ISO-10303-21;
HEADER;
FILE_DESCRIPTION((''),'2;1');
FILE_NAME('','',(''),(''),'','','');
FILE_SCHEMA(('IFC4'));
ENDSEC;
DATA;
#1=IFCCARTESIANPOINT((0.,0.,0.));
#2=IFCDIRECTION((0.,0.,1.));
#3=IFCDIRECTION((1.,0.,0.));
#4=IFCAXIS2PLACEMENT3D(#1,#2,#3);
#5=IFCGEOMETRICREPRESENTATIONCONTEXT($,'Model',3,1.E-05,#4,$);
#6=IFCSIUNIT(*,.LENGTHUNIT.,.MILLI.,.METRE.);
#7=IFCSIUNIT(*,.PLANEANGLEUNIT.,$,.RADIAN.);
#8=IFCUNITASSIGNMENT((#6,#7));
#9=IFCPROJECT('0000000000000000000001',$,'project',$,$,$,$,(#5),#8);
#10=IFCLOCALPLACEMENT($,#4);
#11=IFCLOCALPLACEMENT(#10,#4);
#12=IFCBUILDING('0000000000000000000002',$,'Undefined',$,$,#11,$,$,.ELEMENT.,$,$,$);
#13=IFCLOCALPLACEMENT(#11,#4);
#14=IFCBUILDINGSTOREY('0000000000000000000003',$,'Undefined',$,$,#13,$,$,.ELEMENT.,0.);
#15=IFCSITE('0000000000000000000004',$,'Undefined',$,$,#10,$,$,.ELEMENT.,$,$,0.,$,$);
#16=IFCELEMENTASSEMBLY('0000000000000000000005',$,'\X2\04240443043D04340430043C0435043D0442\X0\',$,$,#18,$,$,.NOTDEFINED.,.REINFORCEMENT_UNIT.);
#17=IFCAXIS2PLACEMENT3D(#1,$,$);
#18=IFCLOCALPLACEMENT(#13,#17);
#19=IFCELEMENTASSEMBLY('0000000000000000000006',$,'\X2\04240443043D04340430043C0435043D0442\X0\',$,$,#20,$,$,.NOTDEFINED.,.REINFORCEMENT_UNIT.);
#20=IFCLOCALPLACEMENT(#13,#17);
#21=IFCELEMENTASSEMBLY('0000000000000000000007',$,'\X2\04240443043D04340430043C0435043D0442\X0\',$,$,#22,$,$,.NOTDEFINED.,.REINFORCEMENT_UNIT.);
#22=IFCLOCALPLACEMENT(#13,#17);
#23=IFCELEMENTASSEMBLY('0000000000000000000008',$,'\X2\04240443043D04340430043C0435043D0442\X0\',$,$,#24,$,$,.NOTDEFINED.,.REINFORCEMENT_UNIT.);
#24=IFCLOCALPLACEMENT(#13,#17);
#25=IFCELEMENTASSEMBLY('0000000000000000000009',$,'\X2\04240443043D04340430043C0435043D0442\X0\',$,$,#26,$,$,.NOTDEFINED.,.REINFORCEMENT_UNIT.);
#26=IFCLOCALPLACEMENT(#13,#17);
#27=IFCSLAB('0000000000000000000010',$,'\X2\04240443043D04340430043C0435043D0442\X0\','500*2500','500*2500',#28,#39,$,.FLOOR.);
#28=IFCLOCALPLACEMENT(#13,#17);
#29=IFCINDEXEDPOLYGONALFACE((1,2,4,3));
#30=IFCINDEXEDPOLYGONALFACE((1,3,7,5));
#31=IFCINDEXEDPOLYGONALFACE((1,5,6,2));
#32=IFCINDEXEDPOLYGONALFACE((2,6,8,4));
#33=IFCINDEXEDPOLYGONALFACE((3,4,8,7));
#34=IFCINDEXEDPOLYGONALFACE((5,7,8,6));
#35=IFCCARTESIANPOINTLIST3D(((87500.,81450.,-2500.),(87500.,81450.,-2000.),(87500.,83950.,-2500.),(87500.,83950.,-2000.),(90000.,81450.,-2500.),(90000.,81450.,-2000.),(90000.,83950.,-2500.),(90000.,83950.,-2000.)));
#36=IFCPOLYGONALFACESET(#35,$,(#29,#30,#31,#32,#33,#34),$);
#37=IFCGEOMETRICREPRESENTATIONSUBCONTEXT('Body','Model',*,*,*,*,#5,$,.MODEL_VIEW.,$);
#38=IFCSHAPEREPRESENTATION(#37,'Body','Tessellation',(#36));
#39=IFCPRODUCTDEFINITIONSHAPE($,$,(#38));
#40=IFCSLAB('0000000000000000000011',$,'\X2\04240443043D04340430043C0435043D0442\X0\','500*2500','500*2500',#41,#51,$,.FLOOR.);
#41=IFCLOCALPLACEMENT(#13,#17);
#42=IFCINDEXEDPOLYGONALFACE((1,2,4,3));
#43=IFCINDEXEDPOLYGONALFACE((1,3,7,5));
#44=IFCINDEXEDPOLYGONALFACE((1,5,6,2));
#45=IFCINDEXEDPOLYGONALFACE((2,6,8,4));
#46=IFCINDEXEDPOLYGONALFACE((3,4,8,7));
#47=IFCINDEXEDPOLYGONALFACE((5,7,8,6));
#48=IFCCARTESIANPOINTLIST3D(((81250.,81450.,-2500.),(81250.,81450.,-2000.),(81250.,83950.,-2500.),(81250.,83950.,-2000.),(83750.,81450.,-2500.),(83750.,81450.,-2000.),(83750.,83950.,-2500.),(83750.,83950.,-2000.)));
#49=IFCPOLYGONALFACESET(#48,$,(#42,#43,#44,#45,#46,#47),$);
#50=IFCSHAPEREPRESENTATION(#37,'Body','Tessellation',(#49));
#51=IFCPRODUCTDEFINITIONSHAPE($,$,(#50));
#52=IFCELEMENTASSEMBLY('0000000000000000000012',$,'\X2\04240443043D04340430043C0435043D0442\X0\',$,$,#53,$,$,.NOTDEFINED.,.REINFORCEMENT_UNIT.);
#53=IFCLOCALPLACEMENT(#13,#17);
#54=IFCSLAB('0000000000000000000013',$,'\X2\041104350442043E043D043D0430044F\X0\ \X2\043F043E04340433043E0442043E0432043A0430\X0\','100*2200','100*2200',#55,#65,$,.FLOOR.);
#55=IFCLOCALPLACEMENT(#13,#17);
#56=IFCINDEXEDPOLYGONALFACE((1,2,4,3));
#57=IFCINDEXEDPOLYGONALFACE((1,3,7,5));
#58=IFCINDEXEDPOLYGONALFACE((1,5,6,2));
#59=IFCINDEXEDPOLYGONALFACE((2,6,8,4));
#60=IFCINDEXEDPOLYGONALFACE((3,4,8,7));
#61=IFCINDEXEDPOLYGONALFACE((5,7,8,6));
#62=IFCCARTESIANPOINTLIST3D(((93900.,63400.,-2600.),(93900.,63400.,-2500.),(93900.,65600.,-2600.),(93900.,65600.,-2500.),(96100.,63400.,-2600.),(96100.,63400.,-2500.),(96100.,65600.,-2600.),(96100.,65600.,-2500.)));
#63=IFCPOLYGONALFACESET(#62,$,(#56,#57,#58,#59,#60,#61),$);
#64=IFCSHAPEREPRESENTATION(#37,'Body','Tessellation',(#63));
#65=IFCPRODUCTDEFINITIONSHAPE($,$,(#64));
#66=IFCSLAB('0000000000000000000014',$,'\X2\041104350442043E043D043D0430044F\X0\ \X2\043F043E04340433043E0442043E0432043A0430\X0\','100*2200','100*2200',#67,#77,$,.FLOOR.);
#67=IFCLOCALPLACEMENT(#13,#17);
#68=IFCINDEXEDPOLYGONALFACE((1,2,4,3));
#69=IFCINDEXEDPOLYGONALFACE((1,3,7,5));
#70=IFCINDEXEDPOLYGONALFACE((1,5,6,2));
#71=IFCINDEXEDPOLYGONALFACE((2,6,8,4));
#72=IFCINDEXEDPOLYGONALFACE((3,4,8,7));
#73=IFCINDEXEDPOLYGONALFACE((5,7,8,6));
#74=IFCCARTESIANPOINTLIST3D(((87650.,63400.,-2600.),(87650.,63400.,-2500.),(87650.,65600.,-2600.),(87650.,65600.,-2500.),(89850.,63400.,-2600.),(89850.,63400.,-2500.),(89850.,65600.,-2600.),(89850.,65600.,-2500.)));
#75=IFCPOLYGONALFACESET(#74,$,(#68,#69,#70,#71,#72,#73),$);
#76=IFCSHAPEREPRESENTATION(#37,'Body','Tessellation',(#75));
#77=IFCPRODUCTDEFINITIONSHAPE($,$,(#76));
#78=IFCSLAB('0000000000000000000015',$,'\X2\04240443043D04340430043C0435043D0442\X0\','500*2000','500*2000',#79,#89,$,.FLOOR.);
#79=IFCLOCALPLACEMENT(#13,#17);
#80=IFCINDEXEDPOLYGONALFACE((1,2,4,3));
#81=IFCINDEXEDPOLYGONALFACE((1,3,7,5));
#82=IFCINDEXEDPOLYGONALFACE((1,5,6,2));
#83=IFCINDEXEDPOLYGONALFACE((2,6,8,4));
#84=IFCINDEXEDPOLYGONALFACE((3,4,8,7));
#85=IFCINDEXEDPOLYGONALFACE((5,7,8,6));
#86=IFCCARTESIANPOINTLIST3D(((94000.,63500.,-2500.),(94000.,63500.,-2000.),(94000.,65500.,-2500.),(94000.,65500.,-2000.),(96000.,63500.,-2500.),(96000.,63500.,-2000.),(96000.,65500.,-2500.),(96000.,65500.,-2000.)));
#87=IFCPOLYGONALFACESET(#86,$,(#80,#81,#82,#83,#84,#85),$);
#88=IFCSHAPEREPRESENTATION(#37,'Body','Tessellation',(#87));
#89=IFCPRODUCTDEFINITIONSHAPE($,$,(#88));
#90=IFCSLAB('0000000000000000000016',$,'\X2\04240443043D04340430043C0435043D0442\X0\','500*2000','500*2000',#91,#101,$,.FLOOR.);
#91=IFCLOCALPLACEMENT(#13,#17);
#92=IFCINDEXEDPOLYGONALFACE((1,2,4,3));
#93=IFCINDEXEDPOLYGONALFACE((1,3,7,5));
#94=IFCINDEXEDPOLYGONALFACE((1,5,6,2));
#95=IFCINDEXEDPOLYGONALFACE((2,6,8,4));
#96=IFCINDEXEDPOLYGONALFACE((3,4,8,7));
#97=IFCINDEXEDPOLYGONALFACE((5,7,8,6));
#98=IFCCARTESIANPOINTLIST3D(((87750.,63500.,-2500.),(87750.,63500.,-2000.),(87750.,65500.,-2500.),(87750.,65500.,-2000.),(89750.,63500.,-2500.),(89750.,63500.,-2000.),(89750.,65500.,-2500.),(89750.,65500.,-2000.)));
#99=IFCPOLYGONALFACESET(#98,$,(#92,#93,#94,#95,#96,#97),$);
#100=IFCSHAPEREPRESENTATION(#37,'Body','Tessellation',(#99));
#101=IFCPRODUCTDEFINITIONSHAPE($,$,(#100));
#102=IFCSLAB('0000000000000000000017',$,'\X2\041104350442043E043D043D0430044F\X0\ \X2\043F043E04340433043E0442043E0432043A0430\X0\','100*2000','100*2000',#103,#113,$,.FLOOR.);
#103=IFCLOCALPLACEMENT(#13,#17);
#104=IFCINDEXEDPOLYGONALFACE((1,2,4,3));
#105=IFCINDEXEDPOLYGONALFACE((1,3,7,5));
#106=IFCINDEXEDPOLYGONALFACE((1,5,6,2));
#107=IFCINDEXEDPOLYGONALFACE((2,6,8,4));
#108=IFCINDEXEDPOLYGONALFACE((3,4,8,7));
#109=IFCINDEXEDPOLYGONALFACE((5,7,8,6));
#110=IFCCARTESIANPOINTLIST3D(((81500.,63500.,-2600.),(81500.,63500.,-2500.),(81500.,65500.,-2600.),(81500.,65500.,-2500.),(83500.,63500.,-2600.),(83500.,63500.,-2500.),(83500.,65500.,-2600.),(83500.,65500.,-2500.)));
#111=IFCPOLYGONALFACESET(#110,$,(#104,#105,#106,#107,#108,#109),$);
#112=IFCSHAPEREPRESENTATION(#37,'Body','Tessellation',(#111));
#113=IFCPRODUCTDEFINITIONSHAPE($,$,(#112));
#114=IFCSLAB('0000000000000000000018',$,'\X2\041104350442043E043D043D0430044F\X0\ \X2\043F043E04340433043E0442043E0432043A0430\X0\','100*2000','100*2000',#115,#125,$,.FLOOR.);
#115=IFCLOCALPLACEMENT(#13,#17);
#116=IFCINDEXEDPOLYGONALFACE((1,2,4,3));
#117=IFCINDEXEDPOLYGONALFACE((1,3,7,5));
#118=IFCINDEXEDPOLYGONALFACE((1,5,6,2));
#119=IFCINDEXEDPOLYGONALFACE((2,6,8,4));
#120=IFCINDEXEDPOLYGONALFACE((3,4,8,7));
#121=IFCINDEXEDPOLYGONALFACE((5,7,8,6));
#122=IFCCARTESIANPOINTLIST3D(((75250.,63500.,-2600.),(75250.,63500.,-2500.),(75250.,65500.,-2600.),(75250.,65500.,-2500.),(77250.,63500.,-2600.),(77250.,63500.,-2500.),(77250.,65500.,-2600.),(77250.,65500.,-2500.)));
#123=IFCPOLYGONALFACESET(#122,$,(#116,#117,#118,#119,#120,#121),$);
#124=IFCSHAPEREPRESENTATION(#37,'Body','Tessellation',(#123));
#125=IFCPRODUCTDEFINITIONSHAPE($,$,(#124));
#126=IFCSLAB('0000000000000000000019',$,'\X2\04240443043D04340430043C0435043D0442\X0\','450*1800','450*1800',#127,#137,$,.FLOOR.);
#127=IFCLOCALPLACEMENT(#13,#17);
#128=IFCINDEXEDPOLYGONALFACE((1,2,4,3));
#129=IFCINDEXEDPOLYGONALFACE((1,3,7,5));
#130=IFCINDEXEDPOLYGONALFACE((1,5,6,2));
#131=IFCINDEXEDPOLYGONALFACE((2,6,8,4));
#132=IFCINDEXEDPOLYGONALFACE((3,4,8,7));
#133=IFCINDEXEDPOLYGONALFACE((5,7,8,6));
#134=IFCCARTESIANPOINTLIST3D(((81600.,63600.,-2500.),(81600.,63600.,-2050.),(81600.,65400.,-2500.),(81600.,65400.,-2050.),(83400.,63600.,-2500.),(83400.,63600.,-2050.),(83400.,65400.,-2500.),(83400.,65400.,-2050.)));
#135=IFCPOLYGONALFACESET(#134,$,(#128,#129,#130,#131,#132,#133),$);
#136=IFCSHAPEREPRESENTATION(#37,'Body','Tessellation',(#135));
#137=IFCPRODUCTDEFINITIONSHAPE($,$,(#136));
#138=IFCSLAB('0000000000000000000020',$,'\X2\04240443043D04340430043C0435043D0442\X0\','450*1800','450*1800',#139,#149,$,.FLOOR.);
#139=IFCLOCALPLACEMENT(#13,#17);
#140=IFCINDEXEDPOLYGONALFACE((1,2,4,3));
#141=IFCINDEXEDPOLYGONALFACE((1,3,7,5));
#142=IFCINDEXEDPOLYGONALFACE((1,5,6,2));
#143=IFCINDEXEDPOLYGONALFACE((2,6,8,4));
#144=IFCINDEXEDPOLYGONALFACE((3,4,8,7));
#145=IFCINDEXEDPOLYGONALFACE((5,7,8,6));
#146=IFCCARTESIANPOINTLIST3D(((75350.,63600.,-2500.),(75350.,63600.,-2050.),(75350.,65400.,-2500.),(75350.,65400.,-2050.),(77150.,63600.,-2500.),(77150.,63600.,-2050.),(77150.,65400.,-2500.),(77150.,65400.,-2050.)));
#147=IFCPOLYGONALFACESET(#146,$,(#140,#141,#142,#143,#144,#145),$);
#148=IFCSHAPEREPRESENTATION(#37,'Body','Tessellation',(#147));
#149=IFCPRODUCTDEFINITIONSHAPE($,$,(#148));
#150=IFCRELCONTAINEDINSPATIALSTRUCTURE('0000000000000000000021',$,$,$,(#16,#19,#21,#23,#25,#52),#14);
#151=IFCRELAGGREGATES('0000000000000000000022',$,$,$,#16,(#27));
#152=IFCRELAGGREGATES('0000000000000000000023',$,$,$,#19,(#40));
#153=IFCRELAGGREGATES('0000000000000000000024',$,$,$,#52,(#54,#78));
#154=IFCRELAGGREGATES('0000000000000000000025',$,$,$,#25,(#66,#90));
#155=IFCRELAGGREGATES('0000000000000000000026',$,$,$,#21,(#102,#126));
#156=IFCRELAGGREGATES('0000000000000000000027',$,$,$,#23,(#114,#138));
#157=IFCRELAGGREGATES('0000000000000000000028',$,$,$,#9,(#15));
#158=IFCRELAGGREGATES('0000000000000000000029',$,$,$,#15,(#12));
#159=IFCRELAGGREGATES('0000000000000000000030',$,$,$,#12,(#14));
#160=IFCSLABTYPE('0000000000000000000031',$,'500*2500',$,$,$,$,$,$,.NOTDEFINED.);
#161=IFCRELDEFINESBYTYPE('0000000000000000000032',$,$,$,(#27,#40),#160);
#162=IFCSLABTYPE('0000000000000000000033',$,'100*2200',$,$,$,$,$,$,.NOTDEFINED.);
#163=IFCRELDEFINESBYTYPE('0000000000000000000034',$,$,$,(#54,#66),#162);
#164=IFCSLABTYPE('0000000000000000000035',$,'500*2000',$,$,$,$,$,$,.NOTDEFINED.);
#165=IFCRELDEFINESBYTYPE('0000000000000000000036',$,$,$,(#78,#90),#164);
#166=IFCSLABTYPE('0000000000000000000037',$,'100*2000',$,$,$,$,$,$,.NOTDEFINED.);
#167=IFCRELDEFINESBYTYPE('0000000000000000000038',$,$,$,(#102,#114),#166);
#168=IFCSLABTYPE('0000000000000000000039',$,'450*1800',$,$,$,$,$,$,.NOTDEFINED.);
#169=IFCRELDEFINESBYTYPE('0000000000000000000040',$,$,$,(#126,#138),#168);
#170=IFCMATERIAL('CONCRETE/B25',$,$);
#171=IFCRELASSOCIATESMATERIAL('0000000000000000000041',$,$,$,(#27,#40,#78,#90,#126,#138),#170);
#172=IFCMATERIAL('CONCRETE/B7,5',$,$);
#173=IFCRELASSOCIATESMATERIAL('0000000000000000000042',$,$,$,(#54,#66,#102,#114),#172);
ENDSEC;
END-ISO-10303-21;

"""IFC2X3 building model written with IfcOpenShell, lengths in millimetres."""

from ifc_helpers import new_model, si_unit, frame, origin_with_axes, place, context, subcontext, project, spatial, polyline, outline, extrude, material, type_object, element, aggregate, save


model = new_model("IFC2X3")

# Units and contexts
model_context = context("Model", 3, precision=1e-05, world=origin_with_axes())
body_context = subcontext(model_context, "Body", "Model", "MODEL_VIEW")
ifc_project = project(units=[si_unit("LENGTHUNIT", "METRE", prefix="MILLI"), si_unit("PLANEANGLEUNIT", "RADIAN")], contexts=[model_context])

# Site, building, storey
site_placement = place(None, origin_with_axes())
site = spatial("IfcSite", under=ifc_project, at=site_placement, Name="Undefined", CompositionType="ELEMENT", RefElevation=0.0)
building_placement = place(site_placement, origin_with_axes())
building = spatial("IfcBuilding", under=site, at=building_placement, Name="Undefined", CompositionType="ELEMENT")
storey_placement = place(building_placement, origin_with_axes())
storey = spatial("IfcBuildingStorey", under=building, at=storey_placement, Name="Undefined", CompositionType="ELEMENT", Elevation=0.0)

# Element assemblies
ifc_material_1 = material(Name="CONCRETE/B25")
assembly_1_placement = place(storey_placement, origin_with_axes())
assembly_1 = element("IfcElementAssembly", 1, at=assembly_1_placement, inside=storey, Name="Фундамент", AssemblyPlace="NOTDEFINED", PredefinedType="REINFORCEMENT_UNIT")
assembly_2_placement = place(storey_placement, origin_with_axes())
assembly_2 = element("IfcElementAssembly", 2, at=assembly_2_placement, inside=storey, Name="Фундамент", AssemblyPlace="NOTDEFINED", PredefinedType="REINFORCEMENT_UNIT")

# Element assemblies
assembly_3_placement = place(storey_placement, origin_with_axes())
assembly_3 = element("IfcElementAssembly", 3, at=assembly_3_placement, inside=storey, Name="Фундамент", AssemblyPlace="NOTDEFINED", PredefinedType="REINFORCEMENT_UNIT")
assembly_4_placement = place(storey_placement, origin_with_axes())
assembly_4 = element("IfcElementAssembly", 4, at=assembly_4_placement, inside=storey, Name="Фундамент", AssemblyPlace="NOTDEFINED", PredefinedType="REINFORCEMENT_UNIT")
assembly_5_placement = place(storey_placement, origin_with_axes())
assembly_5 = element("IfcElementAssembly", 5, at=assembly_5_placement, inside=storey, Name="Фундамент", AssemblyPlace="NOTDEFINED", PredefinedType="REINFORCEMENT_UNIT")

# Slabs
ifc_material_2 = material(Name="CONCRETE/B7,5")
slab_type_1 = type_object("IfcSlabType", Name="500*2500", PredefinedType="NOTDEFINED")
slab_1_placement = place(assembly_1_placement, frame((87500.0, 83950.0, -2250.0), z_axis=(0.0, 0.0, 1.0), x_axis=(0.0, -1.0, 0.0)))
slab_1 = element("IfcSlab", 6, at=slab_1_placement, type_object=slab_type_1, material=ifc_material_1, Name="Фундамент", Description="500*2500", ObjectType="500*2500", PredefinedType="FLOOR", context=body_context, shape_type="SweptSolid", body=[
    extrude(outline(polyline([(0.0, 0.0), (2500.0, 0.0), (2500.0, 2500.0), (0.0, 2500.0), (0.0, 0.0)])), frame((0.0, 0.0, -250.0), z_axis=(0.0, 0.0, 1.0), x_axis=(1.0, 0.0, 0.0)), (0.0, 0.0, 1.0), 500.0),
])
aggregate(assembly_1, [slab_1])
slab_2_placement = place(assembly_2_placement, frame((81250.0, 83950.0, -2250.0), z_axis=(0.0, 0.0, 1.0), x_axis=(0.0, -1.0, 0.0)))
slab_2 = element("IfcSlab", 7, at=slab_2_placement, type_object=slab_type_1, material=ifc_material_1, Name="Фундамент", Description="500*2500", ObjectType="500*2500", PredefinedType="FLOOR", context=body_context, shape_type="SweptSolid", body=[
    extrude(outline(polyline([(0.0, 0.0), (2500.0, 0.0), (2500.0, 2500.0), (0.0, 2500.0), (0.0, 0.0)])), frame((0.0, 0.0, -250.0), z_axis=(0.0, 0.0, 1.0), x_axis=(1.0, 0.0, 0.0)), (0.0, 0.0, 1.0), 500.0),
])
aggregate(assembly_2, [slab_2])

# Element assembly, slab
assembly_6_placement = place(storey_placement, origin_with_axes())
assembly_6 = element("IfcElementAssembly", 8, at=assembly_6_placement, inside=storey, Name="Фундамент", AssemblyPlace="NOTDEFINED", PredefinedType="REINFORCEMENT_UNIT")
slab_type_2 = type_object("IfcSlabType", Name="100*2200", PredefinedType="NOTDEFINED")
slab_3_placement = place(assembly_6_placement, frame((93900.0, 65600.0, -2550.0), z_axis=(0.0, 0.0, 1.0), x_axis=(0.0, -1.0, 0.0)))
slab_3 = element("IfcSlab", 9, at=slab_3_placement, type_object=slab_type_2, material=ifc_material_2, Name="Бетонная подготовка", Description="100*2200", ObjectType="100*2200", PredefinedType="FLOOR", context=body_context, shape_type="SweptSolid", body=[
    extrude(outline(polyline([(0.0, 0.0), (2200.0, 0.0), (2200.0, 2200.0), (0.0, 2200.0), (0.0, 0.0)])), frame((0.0, 0.0, -50.0), z_axis=(0.0, 0.0, 1.0), x_axis=(1.0, 0.0, 0.0)), (0.0, 0.0, 1.0), 100.0),
])

# Slabs
slab_4_placement = place(assembly_5_placement, frame((87650.0, 65600.0, -2550.0), z_axis=(0.0, 0.0, 1.0), x_axis=(0.0, -1.0, 0.0)))
slab_4 = element("IfcSlab", 10, at=slab_4_placement, type_object=slab_type_2, material=ifc_material_2, Name="Бетонная подготовка", Description="100*2200", ObjectType="100*2200", PredefinedType="FLOOR", context=body_context, shape_type="SweptSolid", body=[
    extrude(outline(polyline([(0.0, 0.0), (2200.0, 0.0), (2200.0, 2200.0), (0.0, 2200.0), (0.0, 0.0)])), frame((0.0, 0.0, -50.0), z_axis=(0.0, 0.0, 1.0), x_axis=(1.0, 0.0, 0.0)), (0.0, 0.0, 1.0), 100.0),
])
slab_type_3 = type_object("IfcSlabType", Name="500*2000", PredefinedType="NOTDEFINED")
slab_5_placement = place(assembly_6_placement, frame((94000.0, 65500.0, -2250.0), z_axis=(0.0, 0.0, 1.0), x_axis=(0.0, -1.0, 0.0)))
slab_5 = element("IfcSlab", 11, at=slab_5_placement, type_object=slab_type_3, material=ifc_material_1, Name="Фундамент", Description="500*2000", ObjectType="500*2000", PredefinedType="FLOOR", context=body_context, shape_type="SweptSolid", body=[
    extrude(outline(polyline([(0.0, 0.0), (2000.0, 0.0), (2000.0, 2000.0), (0.0, 2000.0), (0.0, 0.0)])), frame((0.0, 0.0, -250.0), z_axis=(0.0, 0.0, 1.0), x_axis=(1.0, 0.0, 0.0)), (0.0, 0.0, 1.0), 500.0),
])
aggregate(assembly_6, [slab_3, slab_5])
slab_6_placement = place(assembly_5_placement, frame((87750.0, 65500.0, -2250.0), z_axis=(0.0, 0.0, 1.0), x_axis=(0.0, -1.0, 0.0)))
slab_6 = element("IfcSlab", 12, at=slab_6_placement, type_object=slab_type_3, material=ifc_material_1, Name="Фундамент", Description="500*2000", ObjectType="500*2000", PredefinedType="FLOOR", context=body_context, shape_type="SweptSolid", body=[
    extrude(outline(polyline([(0.0, 0.0), (2000.0, 0.0), (2000.0, 2000.0), (0.0, 2000.0), (0.0, 0.0)])), frame((0.0, 0.0, -250.0), z_axis=(0.0, 0.0, 1.0), x_axis=(1.0, 0.0, 0.0)), (0.0, 0.0, 1.0), 500.0),
])
aggregate(assembly_5, [slab_4, slab_6])
slab_type_4 = type_object("IfcSlabType", Name="100*2000", PredefinedType="NOTDEFINED")
slab_7_placement = place(assembly_3_placement, frame((81500.0, 65500.0, -2550.0), z_axis=(0.0, 0.0, 1.0), x_axis=(0.0, -1.0, 0.0)))
slab_7 = element("IfcSlab", 13, at=slab_7_placement, type_object=slab_type_4, material=ifc_material_2, Name="Бетонная подготовка", Description="100*2000", ObjectType="100*2000", PredefinedType="FLOOR", context=body_context, shape_type="SweptSolid", body=[
    extrude(outline(polyline([(0.0, 0.0), (2000.0, 0.0), (2000.0, 2000.0), (0.0, 2000.0), (0.0, 0.0)])), frame((0.0, 0.0, -50.0), z_axis=(0.0, 0.0, 1.0), x_axis=(1.0, 0.0, 0.0)), (0.0, 0.0, 1.0), 100.0),
])
slab_8_placement = place(assembly_4_placement, frame((75250.0, 65500.0, -2550.0), z_axis=(0.0, 0.0, 1.0), x_axis=(0.0, -1.0, 0.0)))
slab_8 = element("IfcSlab", 14, at=slab_8_placement, type_object=slab_type_4, material=ifc_material_2, Name="Бетонная подготовка", Description="100*2000", ObjectType="100*2000", PredefinedType="FLOOR", context=body_context, shape_type="SweptSolid", body=[
    extrude(outline(polyline([(0.0, 0.0), (2000.0, 0.0), (2000.0, 2000.0), (0.0, 2000.0), (0.0, 0.0)])), frame((0.0, 0.0, -50.0), z_axis=(0.0, 0.0, 1.0), x_axis=(1.0, 0.0, 0.0)), (0.0, 0.0, 1.0), 100.0),
])
slab_type_5 = type_object("IfcSlabType", Name="450*1800", PredefinedType="NOTDEFINED")
slab_9_placement = place(assembly_3_placement, frame((81600.0, 65400.0, -2275.0), z_axis=(0.0, 0.0, 1.0), x_axis=(0.0, -1.0, 0.0)))
slab_9 = element("IfcSlab", 15, at=slab_9_placement, type_object=slab_type_5, material=ifc_material_1, Name="Фундамент", Description="450*1800", ObjectType="450*1800", PredefinedType="FLOOR", context=body_context, shape_type="SweptSolid", body=[
    extrude(outline(polyline([(0.0, 0.0), (1800.0, 0.0), (1800.0, 1800.0), (0.0, 1800.0), (0.0, 0.0)])), frame((0.0, 0.0, -225.0), z_axis=(0.0, 0.0, 1.0), x_axis=(1.0, 0.0, 0.0)), (0.0, 0.0, 1.0), 450.0),
])
aggregate(assembly_3, [slab_7, slab_9])
slab_10_placement = place(assembly_4_placement, frame((75350.0, 65400.0, -2275.0), z_axis=(0.0, 0.0, 1.0), x_axis=(0.0, -1.0, 0.0)))
slab_10 = element("IfcSlab", 16, at=slab_10_placement, type_object=slab_type_5, material=ifc_material_1, Name="Фундамент", Description="450*1800", ObjectType="450*1800", PredefinedType="FLOOR", context=body_context, shape_type="SweptSolid", body=[
    extrude(outline(polyline([(0.0, 0.0), (1800.0, 0.0), (1800.0, 1800.0), (0.0, 1800.0), (0.0, 0.0)])), frame((0.0, 0.0, -225.0), z_axis=(0.0, 0.0, 1.0), x_axis=(1.0, 0.0, 0.0)), (0.0, 0.0, 1.0), 450.0),
])
aggregate(assembly_4, [slab_8, slab_10])

save(model, "model.ifc")
